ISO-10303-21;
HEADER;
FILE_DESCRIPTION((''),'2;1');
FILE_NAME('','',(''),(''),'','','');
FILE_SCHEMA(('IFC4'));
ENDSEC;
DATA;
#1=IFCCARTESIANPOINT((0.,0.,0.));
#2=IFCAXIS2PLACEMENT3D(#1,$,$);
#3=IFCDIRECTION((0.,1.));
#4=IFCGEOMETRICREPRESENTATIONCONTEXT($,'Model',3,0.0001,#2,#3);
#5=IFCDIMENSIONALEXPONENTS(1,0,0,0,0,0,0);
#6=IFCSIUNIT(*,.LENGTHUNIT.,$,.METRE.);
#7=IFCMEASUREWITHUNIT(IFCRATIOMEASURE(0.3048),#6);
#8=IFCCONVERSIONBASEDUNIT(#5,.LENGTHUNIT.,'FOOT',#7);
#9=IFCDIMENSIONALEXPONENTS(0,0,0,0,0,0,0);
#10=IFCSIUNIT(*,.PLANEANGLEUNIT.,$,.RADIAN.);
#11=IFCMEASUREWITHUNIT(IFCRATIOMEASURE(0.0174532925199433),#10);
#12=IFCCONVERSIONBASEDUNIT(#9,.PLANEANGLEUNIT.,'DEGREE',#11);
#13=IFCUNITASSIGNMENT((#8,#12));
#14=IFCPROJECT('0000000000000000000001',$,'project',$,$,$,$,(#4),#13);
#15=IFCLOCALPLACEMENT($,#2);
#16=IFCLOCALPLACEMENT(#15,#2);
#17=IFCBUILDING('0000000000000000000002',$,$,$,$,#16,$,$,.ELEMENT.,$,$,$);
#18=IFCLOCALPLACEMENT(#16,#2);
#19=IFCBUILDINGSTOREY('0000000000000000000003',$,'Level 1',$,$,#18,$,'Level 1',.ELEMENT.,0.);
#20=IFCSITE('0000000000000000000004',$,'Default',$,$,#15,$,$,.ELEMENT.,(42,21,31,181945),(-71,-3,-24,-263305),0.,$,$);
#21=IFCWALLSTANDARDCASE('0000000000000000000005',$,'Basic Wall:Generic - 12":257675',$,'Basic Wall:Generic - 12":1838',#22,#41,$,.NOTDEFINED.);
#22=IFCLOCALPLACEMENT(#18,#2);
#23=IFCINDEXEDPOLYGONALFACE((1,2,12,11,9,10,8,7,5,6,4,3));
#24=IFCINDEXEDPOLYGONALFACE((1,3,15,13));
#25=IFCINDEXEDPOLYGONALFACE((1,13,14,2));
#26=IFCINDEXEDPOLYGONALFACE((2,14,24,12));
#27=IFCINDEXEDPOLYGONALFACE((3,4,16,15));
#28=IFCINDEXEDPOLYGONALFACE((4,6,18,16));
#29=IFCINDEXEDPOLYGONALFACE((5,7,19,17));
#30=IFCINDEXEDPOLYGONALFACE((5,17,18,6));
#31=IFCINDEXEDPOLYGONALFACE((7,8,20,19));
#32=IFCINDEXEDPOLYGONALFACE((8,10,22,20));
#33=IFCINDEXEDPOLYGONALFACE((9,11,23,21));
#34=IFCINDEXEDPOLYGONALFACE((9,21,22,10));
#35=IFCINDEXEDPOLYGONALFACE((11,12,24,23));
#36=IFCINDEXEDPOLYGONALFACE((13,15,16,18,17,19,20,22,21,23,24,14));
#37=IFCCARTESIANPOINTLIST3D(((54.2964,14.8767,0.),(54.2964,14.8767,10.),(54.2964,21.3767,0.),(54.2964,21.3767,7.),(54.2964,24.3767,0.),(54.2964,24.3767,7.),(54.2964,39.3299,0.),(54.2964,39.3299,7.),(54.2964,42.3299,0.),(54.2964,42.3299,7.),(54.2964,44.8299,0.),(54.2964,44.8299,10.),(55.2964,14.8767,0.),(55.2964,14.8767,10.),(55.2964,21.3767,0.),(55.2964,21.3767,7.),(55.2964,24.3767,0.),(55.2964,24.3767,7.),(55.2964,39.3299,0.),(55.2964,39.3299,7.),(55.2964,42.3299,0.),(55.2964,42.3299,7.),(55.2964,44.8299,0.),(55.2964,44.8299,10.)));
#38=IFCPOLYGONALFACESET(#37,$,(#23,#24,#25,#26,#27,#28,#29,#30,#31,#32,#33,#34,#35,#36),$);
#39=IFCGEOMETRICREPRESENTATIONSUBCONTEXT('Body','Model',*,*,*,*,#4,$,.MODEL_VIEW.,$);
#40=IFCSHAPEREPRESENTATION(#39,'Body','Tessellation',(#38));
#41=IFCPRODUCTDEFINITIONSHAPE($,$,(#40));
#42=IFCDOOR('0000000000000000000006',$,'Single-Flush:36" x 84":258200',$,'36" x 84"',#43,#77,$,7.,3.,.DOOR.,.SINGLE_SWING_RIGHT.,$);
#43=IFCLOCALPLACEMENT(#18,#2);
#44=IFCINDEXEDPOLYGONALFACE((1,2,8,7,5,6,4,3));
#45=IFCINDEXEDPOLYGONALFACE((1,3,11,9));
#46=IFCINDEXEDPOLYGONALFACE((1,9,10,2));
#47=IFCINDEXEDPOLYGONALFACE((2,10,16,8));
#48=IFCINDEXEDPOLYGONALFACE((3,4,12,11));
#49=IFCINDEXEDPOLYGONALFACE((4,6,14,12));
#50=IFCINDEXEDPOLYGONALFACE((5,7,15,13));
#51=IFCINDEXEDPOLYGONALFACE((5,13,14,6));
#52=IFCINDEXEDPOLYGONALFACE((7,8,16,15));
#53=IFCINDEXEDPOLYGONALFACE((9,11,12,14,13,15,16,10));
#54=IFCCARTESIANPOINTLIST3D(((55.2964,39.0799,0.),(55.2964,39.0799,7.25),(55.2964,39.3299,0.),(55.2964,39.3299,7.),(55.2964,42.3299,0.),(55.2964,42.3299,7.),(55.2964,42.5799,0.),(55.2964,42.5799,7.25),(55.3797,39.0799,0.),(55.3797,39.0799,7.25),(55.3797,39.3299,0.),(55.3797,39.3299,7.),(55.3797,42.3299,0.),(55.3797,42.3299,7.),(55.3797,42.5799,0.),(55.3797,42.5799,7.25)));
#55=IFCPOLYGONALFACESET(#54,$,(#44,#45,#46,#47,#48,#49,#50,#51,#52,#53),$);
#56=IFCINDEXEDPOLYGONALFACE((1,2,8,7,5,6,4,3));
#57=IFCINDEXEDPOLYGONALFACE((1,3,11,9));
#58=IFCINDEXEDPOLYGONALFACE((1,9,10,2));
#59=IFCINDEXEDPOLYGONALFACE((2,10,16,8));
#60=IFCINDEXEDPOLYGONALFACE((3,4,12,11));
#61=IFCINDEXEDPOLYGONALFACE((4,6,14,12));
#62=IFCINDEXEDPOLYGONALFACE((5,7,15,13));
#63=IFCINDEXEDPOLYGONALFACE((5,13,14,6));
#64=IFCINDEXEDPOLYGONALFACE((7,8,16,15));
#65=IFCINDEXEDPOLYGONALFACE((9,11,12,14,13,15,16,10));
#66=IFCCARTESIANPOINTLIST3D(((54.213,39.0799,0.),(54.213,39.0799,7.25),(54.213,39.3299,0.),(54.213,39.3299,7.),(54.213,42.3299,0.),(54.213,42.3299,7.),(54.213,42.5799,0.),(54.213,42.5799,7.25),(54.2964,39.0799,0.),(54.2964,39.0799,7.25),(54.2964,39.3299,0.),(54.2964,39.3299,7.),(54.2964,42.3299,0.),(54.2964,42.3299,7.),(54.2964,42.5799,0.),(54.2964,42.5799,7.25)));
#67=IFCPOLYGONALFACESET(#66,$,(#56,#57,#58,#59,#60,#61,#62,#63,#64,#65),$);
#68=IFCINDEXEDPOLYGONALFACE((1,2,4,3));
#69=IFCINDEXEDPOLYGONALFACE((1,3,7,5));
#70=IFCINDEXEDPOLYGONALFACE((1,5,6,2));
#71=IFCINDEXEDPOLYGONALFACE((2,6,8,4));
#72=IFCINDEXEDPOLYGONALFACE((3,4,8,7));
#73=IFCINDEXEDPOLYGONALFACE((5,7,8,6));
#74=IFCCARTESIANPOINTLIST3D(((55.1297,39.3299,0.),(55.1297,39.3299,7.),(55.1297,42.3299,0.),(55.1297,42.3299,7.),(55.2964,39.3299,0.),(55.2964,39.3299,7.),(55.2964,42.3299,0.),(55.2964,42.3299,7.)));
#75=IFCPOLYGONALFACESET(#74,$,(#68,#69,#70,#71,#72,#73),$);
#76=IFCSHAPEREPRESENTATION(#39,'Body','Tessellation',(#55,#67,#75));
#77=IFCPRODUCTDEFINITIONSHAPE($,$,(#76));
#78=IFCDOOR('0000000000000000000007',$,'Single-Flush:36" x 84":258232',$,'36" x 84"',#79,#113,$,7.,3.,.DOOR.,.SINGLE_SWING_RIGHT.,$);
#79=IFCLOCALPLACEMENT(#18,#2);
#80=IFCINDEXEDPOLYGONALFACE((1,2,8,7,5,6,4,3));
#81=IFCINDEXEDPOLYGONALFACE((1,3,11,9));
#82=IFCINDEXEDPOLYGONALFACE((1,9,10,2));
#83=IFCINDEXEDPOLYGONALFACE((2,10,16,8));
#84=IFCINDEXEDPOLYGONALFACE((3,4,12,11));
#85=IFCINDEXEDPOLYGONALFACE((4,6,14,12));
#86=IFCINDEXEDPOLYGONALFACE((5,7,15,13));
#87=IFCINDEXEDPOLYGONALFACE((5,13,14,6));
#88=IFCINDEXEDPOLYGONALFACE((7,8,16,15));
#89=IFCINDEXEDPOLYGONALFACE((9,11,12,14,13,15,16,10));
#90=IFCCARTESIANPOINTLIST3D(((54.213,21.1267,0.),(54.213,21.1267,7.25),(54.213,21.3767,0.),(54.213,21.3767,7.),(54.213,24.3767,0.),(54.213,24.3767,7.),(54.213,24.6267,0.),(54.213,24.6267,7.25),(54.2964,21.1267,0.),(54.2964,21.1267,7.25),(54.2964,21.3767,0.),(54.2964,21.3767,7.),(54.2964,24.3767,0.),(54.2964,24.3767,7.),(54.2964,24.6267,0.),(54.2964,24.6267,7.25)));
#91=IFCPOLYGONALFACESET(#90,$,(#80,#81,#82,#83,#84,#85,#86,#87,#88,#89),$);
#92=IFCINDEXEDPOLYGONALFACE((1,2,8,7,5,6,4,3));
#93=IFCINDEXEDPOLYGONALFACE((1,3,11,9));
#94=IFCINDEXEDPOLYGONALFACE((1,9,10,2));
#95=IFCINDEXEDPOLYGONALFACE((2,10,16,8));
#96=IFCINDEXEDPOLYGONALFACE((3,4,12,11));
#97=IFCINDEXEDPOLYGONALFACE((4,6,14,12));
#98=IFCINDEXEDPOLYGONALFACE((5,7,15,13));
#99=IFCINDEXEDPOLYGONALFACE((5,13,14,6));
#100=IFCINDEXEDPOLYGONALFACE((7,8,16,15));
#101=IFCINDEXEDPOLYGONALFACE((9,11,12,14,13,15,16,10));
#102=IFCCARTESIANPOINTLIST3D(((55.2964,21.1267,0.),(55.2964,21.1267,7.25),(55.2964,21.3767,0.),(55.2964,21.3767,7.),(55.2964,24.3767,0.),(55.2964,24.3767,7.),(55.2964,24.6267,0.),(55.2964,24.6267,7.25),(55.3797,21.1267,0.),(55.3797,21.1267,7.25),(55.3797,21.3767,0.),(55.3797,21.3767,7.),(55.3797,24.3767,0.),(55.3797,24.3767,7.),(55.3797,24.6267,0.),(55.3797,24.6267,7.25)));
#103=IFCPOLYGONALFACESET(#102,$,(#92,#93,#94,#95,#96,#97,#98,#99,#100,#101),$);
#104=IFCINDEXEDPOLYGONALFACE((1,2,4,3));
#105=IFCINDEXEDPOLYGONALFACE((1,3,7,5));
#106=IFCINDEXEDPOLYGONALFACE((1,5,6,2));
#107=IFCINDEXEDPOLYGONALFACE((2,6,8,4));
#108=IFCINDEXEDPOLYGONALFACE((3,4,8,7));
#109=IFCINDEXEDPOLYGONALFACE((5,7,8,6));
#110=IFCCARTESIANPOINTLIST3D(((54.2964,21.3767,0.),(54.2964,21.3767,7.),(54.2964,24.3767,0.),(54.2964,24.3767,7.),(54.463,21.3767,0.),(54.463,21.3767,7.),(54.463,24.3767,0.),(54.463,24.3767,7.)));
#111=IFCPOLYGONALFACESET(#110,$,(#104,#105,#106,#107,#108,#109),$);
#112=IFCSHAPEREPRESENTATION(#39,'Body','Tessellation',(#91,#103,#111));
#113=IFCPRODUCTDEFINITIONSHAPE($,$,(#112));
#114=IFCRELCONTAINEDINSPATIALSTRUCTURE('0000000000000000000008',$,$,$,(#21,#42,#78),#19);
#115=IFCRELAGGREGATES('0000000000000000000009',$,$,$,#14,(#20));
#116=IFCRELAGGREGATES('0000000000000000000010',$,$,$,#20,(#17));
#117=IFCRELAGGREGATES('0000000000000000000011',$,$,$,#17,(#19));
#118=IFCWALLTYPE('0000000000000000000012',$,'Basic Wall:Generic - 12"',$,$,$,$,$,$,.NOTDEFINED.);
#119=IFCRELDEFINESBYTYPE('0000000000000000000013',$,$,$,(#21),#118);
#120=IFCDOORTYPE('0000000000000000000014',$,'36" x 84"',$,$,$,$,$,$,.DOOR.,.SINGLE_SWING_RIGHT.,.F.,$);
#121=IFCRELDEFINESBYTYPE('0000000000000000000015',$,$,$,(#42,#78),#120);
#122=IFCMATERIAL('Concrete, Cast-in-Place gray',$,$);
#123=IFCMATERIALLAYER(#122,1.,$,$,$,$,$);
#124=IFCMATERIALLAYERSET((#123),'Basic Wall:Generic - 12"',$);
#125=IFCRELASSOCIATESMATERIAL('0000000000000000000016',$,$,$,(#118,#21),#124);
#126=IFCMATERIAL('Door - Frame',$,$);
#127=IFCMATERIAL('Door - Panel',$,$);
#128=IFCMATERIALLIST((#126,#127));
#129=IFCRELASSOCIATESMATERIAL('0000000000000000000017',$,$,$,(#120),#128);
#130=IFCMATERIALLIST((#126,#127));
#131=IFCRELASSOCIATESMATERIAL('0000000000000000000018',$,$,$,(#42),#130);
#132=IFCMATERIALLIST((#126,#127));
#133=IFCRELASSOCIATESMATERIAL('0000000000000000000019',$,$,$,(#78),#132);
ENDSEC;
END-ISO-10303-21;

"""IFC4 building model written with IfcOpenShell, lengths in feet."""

from ifc_helpers import new_model, entity, si_unit, converted_unit, direction, frame, frame_2d, origin, place, context, subcontext, project, spatial, polyline, rectangle, outline, extrude, source, transform, mapped, material, material_list, layer, layer_set, layer_usage, type_object, type_shapes, element, fill, save


model = new_model("IFC4")

# Units and contexts
model_context = context("Model", 3, precision=0.0001, world=origin(), true_north=direction((0.0, 1.0)))
body_context = subcontext(model_context, "Body", "Model", "MODEL_VIEW")
ifc_project = project(units=[converted_unit("LENGTHUNIT", "FOOT", entity("IfcRatioMeasure", 0.3048), si_unit("LENGTHUNIT", "METRE"), dimensions=[1, 0, 0, 0, 0, 0, 0]), converted_unit("PLANEANGLEUNIT", "DEGREE", entity("IfcRatioMeasure", 0.0174532925199433), si_unit("PLANEANGLEUNIT", "RADIAN"), dimensions=[0, 0, 0, 0, 0, 0, 0])], contexts=[model_context])

# Site, building, storey
site_placement = place(None, origin())
site = spatial("IfcSite", under=ifc_project, at=site_placement, Name="Default", CompositionType="ELEMENT", RefLatitude=(42, 21, 31, 181945), RefLongitude=(-71, -3, -24, -263305), RefElevation=0.0)
building_placement = place(site_placement, origin())
building = spatial("IfcBuilding", under=site, at=building_placement, CompositionType="ELEMENT")
storey_placement = place(building_placement, origin())
storey = spatial("IfcBuildingStorey", under=building, at=storey_placement, Name="Level 1", LongName="Level 1", CompositionType="ELEMENT", Elevation=0.0)

# Shared definitions
ifc_material_1 = material(Name="Concrete, Cast-in-Place gray")
ifc_layer = layer(ifc_material_1, 1.0)
ifc_layer_set = layer_set([ifc_layer], Name="Basic Wall:Generic - 12\"")
wall_type = type_object("IfcWallType", Name="Basic Wall:Generic - 12\"", PredefinedType="NOTDEFINED", material=ifc_layer_set)
ifc_material_2 = material(Name="Door - Frame")
ifc_material_3 = material(Name="Door - Panel")
ifc_material_list_1 = material_list([ifc_material_2, ifc_material_3])
door_type = type_object("IfcDoorType", Name="36\" x 84\"", OperationType="SINGLE_SWING_RIGHT", ParameterTakesPrecedence=False, PredefinedType="DOOR", material=ifc_material_list_1)
shared_shape_1 = source(origin(), body_context, "Body", "SweptSolid", [
    extrude(outline(polyline([(-1.75, -3.6875), (1.75, -3.6875), (1.75, 3.5625), (1.5, 3.5625), (1.5, -3.4375), (-1.5, -3.4375), (-1.5, 3.5625), (-1.75, 3.5625), (-1.75, -3.6875)])), frame((1.5, 1.0, 3.5625), z_axis=(0.0, 1.0, 0.0), x_axis=(1.0, 0.0, 0.0)), (0.0, 0.0, 1.0), 0.0833),
    extrude(outline(polyline([(-3.6875, -1.75), (3.5625, -1.75), (3.5625, -1.5), (-3.4375, -1.5), (-3.4375, 1.5), (3.5625, 1.5), (3.5625, 1.75), (-3.6875, 1.75), (-3.6875, -1.75)])), frame((1.5, -0.0833, 3.5625), z_axis=(0.0, 1.0, 0.0), x_axis=(0.0, 0.0, -1.0)), (0.0, 0.0, 1.0), 0.0833),
    extrude(rectangle(XDim=0.1667, YDim=3.0, at=frame_2d((0.0, 0.0), x_axis=(1.0, 0.0))), frame((1.5, 0.9167, 0.0), z_axis=(0.0, 0.0, 1.0), x_axis=(0.0, 1.0, 0.0)), (0.0, 0.0, 1.0), 7.0),
])
type_shapes(door_type, [shared_shape_1])

# Wall, openings, doors
ifc_layer_usage_1 = layer_usage(ifc_layer_set, "AXIS2", "NEGATIVE", 0.5)
wall_1_placement = place(storey_placement, frame((54.7964, 44.8299, 0.0), z_axis=(0.0, 0.0, 1.0), x_axis=(0.0, -1.0, 0.0)))
wall_1 = element("IfcWallStandardCase", 1, at=wall_1_placement, inside=storey, type_object=wall_type, material=ifc_layer_usage_1, Name="Basic Wall:Generic - 12\":257675", ObjectType="Basic Wall:Generic - 12\":1838", PredefinedType="NOTDEFINED", context=body_context, shape_type="SweptSolid", body=[
    extrude(rectangle(XDim=29.9532, YDim=1.0, at=frame_2d((14.9766, 0.0), x_axis=(-1.0, 0.0))), origin(), (0.0, 0.0, 1.0), 10.0),
])
opening_1_placement = place(wall_1_placement, frame((2.5, -0.5, 0.0)))
opening_1 = element("IfcOpeningElement", 2, at=opening_1_placement, cuts=wall_1, ObjectType="Opening", PredefinedType="OPENING", context=body_context, shape_type="SweptSolid", body=[
    extrude(rectangle(XDim=3.0, YDim=7.0, at=frame_2d((3.5, 1.5), x_axis=(0.0, 1.0))), frame((0.0, 0.0, 0.0), z_axis=(0.0, 1.0, 0.0), x_axis=(0.0, 0.0, 1.0)), (0.0, 0.0, 1.0), 1.0),
])
opening_2_placement = place(wall_1_placement, frame((23.4532, 0.5, 0.0)))
opening_2 = element("IfcOpeningElement", 3, at=opening_2_placement, cuts=wall_1, ObjectType="Opening", PredefinedType="OPENING", context=body_context, shape_type="SweptSolid", body=[
    extrude(rectangle(XDim=3.0, YDim=7.0, at=frame_2d((3.5, 1.5), x_axis=(0.0, 1.0))), frame((0.0, 0.0, 0.0), z_axis=(0.0, -1.0, 0.0), x_axis=(0.0, 0.0, 1.0)), (0.0, 0.0, 1.0), 1.0),
])
ifc_material_list_2 = material_list([ifc_material_2, ifc_material_3])
door_1_placement = place(opening_1_placement, origin())
door_1 = element("IfcDoor", 4, at=door_1_placement, inside=storey, type_object=door_type, material=ifc_material_list_2, Name="Single-Flush:36\" x 84\":258200", ObjectType="36\" x 84\"", OperationType="SINGLE_SWING_RIGHT", OverallHeight=7.0, OverallWidth=3.0, PredefinedType="DOOR", context=body_context, shape_type="MappedRepresentation", body=[
    mapped(shared_shape_1, transform((0.0, 0.0, 0.0), scale=1.0)),
])
fill(opening_1, door_1)
ifc_material_list_3 = material_list([ifc_material_2, ifc_material_3])
door_2_placement = place(opening_2_placement, frame((0.0, 0.0, 0.0), z_axis=(0.0, 0.0, 1.0), x_axis=(-1.0, 0.0, 0.0)))
door_2 = element("IfcDoor", 5, at=door_2_placement, inside=storey, type_object=door_type, material=ifc_material_list_3, Name="Single-Flush:36\" x 84\":258232", ObjectType="36\" x 84\"", OperationType="SINGLE_SWING_RIGHT", OverallHeight=7.0, OverallWidth=3.0, PredefinedType="DOOR", context=body_context, shape_type="MappedRepresentation", body=[
    mapped(shared_shape_1, transform((0.0, 0.0, 0.0), scale=1.0)),
])
fill(opening_2, door_2)

save(model, "model.ifc")
